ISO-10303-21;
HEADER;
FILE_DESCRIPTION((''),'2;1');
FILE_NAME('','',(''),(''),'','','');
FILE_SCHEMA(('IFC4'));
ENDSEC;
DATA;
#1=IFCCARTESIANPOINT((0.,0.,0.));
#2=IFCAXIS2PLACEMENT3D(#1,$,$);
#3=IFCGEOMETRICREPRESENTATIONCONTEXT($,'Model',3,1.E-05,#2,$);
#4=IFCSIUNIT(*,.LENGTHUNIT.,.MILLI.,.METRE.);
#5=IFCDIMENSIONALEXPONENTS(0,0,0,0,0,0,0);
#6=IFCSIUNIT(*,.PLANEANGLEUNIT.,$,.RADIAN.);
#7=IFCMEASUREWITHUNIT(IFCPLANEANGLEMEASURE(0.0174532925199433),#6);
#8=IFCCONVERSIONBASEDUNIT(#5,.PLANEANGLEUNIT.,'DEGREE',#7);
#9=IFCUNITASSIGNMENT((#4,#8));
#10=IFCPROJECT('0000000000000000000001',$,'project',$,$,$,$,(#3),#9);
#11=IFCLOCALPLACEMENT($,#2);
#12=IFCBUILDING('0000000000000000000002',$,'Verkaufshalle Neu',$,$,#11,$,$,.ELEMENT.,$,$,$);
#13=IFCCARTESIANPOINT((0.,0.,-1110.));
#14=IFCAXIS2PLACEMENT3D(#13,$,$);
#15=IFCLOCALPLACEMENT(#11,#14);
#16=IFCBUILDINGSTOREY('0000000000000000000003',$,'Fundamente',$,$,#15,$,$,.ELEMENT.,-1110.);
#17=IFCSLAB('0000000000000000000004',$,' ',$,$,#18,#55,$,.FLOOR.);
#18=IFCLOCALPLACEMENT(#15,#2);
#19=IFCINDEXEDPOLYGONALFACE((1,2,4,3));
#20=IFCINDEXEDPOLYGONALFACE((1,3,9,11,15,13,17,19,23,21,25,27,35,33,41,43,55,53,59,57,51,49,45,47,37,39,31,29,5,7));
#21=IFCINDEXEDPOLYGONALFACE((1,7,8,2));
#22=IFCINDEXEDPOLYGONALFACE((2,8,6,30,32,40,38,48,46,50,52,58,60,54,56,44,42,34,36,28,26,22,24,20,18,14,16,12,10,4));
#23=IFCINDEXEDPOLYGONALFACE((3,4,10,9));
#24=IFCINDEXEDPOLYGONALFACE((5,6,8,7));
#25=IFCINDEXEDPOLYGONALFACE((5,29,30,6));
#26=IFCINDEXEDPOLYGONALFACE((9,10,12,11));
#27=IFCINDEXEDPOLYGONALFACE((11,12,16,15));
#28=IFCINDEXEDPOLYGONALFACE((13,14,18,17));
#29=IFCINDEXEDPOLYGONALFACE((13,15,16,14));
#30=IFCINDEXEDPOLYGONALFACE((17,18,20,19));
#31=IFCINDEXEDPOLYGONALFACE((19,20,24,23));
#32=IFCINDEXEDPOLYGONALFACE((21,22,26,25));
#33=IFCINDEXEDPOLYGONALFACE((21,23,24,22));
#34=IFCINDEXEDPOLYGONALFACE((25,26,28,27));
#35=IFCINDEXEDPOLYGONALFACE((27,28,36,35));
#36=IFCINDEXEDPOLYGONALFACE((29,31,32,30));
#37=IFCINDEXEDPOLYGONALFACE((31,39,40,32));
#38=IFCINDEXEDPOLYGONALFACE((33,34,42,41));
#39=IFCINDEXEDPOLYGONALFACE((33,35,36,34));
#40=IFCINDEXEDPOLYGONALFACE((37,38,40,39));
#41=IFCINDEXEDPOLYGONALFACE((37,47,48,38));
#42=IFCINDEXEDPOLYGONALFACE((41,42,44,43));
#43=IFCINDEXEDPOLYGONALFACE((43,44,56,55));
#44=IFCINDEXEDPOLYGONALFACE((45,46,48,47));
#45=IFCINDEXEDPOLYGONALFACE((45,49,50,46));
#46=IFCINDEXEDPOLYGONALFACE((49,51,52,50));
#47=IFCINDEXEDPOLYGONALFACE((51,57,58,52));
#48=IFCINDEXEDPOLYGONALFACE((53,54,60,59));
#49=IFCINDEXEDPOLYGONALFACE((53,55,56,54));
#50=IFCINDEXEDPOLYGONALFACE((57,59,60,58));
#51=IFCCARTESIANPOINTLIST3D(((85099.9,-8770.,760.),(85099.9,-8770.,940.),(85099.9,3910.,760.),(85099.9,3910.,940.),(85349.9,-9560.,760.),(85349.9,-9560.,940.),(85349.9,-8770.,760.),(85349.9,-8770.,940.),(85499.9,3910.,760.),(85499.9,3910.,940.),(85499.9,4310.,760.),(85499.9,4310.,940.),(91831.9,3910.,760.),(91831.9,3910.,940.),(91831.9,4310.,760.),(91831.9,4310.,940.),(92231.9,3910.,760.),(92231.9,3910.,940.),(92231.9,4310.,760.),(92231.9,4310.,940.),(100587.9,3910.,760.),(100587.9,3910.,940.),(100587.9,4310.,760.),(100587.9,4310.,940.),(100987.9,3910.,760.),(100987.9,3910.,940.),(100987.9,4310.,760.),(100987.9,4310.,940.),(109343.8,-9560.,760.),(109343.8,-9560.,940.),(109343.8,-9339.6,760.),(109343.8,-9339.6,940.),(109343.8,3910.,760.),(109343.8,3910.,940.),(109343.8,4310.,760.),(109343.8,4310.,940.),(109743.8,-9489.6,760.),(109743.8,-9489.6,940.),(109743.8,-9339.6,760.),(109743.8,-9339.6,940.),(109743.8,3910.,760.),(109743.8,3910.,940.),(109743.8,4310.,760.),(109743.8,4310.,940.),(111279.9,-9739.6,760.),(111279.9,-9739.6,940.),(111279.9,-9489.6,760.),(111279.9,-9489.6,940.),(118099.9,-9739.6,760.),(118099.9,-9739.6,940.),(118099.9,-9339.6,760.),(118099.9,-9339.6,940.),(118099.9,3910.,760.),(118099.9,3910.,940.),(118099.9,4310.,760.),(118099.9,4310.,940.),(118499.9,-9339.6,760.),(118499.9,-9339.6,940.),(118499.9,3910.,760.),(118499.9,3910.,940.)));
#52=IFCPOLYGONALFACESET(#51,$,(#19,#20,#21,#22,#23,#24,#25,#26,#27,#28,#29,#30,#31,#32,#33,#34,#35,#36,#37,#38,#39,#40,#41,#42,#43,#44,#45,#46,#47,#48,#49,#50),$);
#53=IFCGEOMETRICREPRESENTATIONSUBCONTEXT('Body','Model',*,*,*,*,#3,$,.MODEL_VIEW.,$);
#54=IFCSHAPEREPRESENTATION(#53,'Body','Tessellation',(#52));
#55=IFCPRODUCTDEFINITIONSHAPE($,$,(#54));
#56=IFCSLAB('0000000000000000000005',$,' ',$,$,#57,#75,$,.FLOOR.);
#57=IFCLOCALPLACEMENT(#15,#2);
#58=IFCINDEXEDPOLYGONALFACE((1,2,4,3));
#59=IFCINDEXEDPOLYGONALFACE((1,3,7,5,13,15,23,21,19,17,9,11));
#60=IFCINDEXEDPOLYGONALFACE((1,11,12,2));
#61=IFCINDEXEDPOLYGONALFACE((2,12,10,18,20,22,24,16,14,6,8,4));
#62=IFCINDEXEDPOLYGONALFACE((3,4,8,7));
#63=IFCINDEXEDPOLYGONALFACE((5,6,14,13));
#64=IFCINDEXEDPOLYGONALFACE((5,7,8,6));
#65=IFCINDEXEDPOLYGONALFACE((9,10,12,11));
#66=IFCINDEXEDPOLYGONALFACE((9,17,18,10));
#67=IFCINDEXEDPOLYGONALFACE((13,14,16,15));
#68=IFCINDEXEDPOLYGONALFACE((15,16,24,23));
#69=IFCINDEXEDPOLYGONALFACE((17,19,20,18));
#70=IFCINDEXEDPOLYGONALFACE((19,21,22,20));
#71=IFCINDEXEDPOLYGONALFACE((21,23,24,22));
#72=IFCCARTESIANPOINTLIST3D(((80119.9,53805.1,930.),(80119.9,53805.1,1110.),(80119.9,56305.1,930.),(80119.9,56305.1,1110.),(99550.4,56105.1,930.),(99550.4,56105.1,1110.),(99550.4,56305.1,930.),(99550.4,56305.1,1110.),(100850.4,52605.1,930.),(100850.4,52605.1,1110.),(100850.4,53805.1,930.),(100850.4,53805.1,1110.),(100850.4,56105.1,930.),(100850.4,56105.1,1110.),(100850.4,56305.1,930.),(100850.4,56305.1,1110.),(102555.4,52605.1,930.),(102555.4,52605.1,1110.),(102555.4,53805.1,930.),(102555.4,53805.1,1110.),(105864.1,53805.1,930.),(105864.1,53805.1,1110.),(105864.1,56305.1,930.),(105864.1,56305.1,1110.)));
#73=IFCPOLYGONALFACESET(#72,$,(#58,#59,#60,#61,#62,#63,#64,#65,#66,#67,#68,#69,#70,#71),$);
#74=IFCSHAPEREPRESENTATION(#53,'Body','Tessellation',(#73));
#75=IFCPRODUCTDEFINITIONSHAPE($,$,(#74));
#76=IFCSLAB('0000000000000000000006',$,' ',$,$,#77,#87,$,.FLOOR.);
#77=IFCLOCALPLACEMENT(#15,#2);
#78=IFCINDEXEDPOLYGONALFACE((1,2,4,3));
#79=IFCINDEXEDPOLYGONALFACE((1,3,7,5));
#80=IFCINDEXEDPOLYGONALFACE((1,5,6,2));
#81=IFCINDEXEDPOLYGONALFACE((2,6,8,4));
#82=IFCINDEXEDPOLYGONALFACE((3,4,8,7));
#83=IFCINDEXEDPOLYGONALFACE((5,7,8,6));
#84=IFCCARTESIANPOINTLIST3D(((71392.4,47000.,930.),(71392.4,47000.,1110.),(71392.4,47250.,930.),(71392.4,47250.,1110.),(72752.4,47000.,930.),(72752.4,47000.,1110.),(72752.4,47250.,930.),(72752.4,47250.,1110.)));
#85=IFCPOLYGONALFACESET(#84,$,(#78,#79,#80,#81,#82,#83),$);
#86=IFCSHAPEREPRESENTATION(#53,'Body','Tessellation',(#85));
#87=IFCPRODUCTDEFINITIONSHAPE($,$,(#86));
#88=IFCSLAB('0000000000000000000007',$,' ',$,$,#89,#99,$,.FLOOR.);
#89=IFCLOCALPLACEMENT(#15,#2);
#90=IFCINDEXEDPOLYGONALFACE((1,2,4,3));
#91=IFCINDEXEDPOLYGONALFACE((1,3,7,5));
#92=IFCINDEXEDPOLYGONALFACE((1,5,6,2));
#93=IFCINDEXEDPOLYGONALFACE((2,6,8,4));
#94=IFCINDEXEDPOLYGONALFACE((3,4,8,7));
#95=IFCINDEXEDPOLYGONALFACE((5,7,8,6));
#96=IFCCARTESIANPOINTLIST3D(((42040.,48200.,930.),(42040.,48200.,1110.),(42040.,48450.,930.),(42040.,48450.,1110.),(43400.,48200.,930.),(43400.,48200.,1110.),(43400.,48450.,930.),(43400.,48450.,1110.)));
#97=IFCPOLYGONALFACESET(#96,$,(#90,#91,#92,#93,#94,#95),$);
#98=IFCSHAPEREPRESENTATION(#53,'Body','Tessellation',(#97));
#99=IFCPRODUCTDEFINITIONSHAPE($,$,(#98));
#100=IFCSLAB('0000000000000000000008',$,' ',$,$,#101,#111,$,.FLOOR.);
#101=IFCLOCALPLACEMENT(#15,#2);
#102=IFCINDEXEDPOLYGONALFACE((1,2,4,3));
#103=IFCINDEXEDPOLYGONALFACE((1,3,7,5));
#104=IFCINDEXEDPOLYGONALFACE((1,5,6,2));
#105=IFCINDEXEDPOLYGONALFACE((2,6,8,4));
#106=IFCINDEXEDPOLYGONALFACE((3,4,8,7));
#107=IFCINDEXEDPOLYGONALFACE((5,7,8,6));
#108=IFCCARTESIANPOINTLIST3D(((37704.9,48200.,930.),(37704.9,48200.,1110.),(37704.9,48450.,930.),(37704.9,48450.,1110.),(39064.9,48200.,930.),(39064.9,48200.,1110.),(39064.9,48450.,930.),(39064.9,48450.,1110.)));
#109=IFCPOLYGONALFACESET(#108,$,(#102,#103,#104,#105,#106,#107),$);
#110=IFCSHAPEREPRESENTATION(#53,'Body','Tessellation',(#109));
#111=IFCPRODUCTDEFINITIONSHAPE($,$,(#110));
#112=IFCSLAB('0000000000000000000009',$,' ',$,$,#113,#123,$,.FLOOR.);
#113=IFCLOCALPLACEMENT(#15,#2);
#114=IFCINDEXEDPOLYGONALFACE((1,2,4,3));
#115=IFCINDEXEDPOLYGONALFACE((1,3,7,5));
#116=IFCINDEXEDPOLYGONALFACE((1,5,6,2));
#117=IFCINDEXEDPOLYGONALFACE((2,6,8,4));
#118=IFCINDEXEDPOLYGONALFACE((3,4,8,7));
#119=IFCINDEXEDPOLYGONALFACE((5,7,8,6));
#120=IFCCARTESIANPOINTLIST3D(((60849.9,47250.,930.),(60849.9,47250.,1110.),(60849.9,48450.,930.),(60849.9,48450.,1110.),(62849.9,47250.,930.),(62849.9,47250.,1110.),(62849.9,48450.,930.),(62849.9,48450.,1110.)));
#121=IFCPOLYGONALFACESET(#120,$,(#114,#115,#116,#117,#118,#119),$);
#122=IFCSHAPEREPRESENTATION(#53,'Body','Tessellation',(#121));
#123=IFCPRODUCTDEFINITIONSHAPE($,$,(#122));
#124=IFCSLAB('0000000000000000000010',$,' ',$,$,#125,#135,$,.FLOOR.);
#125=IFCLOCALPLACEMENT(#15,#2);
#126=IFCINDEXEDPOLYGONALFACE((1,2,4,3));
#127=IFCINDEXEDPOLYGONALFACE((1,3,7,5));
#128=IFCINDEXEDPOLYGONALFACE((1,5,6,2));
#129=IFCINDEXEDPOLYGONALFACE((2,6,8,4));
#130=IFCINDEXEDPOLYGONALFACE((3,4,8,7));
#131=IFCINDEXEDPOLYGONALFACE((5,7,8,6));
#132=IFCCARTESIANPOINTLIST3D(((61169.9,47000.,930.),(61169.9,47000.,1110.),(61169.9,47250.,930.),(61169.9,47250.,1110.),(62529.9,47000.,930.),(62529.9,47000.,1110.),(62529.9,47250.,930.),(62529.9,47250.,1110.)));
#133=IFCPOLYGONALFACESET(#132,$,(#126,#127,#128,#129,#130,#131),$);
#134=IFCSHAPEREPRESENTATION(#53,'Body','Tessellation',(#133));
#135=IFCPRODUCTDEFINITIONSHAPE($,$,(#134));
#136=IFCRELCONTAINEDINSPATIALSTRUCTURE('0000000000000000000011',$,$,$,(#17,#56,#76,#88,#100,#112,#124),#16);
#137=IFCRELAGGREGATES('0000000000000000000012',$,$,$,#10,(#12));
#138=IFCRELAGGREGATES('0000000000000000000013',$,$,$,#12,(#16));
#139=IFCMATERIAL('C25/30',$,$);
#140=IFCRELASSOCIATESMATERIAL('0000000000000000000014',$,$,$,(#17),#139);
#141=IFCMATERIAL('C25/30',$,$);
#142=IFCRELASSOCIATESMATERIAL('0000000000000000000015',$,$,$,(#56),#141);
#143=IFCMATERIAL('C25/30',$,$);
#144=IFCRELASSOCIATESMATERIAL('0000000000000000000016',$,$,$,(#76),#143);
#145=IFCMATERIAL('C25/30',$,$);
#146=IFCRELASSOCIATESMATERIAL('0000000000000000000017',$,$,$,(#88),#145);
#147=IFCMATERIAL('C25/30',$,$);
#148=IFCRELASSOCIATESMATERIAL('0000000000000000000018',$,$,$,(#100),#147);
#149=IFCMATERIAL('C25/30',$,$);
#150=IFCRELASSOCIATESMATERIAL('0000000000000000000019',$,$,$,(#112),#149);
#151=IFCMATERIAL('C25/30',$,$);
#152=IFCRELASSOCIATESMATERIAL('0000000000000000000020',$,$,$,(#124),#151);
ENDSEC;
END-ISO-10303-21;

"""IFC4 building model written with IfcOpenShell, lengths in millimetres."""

from ifc_helpers import new_model, entity, si_unit, converted_unit, frame, frame_2d, origin, origin_with_axes, place, context, subcontext, project, spatial, polyline, rectangle, outline, extrude, material, element, save


model = new_model("IFC4")

# Units and contexts
model_context = context("Model", 3, precision=1e-05, world=origin())
body_context = subcontext(model_context, "Body", "Model", "MODEL_VIEW")
ifc_project = project(units=[si_unit("LENGTHUNIT", "METRE", prefix="MILLI"), converted_unit("PLANEANGLEUNIT", "DEGREE", entity("IfcPlaneAngleMeasure", 0.0174532925199433), si_unit("PLANEANGLEUNIT", "RADIAN"), dimensions=[0, 0, 0, 0, 0, 0, 0])], contexts=[model_context])

# Building, storey
building_placement = place(None, origin())
building = spatial("IfcBuilding", under=ifc_project, at=building_placement, Name="Verkaufshalle Neu", CompositionType="ELEMENT")
storey_placement = place(building_placement, frame((0.0, 0.0, -1110.0)))
storey = spatial("IfcBuildingStorey", under=building, at=storey_placement, Name="Fundamente", CompositionType="ELEMENT", Elevation=-1110.0)

# Slab
ifc_material_1 = material(Name="C25/30")
slab_1_placement = place(storey_placement, frame((85099.9, -9739.6, 760.0)))
element("IfcSlab", 1, at=slab_1_placement, inside=storey, material=ifc_material_1, Name=" ", PredefinedType="FLOOR", context=body_context, shape_type="SweptSolid", body=[
    extrude(outline(polyline([(0.0, 969.6), (250.0, 969.6), (250.0, 179.6), (24243.9, 179.6), (24243.9, 400.0), (24643.9, 400.0), (24643.9, 250.0), (26180.0, 250.0), (26180.0, 0.0), (33000.0, 0.0), (33000.0, 400.0), (33400.0, 400.0), (33400.0, 13649.6), (33000.0, 13649.6), (33000.0, 14049.6), (24643.9, 14049.6), (24643.9, 13649.6), (24243.9, 13649.6), (24243.9, 14049.6), (15888.0, 14049.6), (15888.0, 13649.6), (15488.0, 13649.6), (15488.0, 14049.6), (7132.0, 14049.6), (7132.0, 13649.6), (6732.0, 13649.6), (6732.0, 14049.6), (400.0, 14049.6), (400.0, 13649.6), (0.0, 13649.6), (0.0, 969.6)])), origin_with_axes(), (0.0, 0.0, 1.0), 180.0),
])

# Slab, opening
ifc_material_2 = material(Name="C25/30")
slab_2_placement = place(storey_placement, frame((80119.9, 52605.1, 930.0)))
slab_2 = element("IfcSlab", 2, at=slab_2_placement, inside=storey, material=ifc_material_2, Name=" ", PredefinedType="FLOOR", context=body_context, shape_type="SweptSolid", body=[
    extrude(outline(polyline([(0.0, 1200.0), (20730.5, 1200.0), (20730.5, 0.0), (22435.5, 0.0), (22435.5, 1200.0), (25744.1, 1200.0), (25744.1, 3700.0), (0.0, 3700.0), (0.0, 1200.0)])), origin_with_axes(), (0.0, 0.0, 1.0), 180.0),
])
opening_1_placement = place(slab_2_placement, frame((19430.5, 3500.0, 0.0)))
element("IfcOpeningStandardCase", 3, at=opening_1_placement, cuts=slab_2, PredefinedType="OPENING", context=body_context, shape_type="SweptSolid", body=[
    extrude(rectangle(XDim=200.0, YDim=1300.0, at=frame_2d((0.0, 0.0), x_axis=(0.0, -1.0))), frame((650.0, 100.0, 0.0), z_axis=(0.0, 0.0, 1.0), x_axis=(1.0, 0.0, 0.0)), (0.0, 0.0, 1.0), 180.0),
])

# Slabs
ifc_material_3 = material(Name="C25/30")
slab_3_placement = place(storey_placement, frame((71392.4, 47000.0, 930.0)))
element("IfcSlab", 4, at=slab_3_placement, inside=storey, material=ifc_material_3, Name=" ", PredefinedType="FLOOR", context=body_context, shape_type="SweptSolid", body=[
    extrude(rectangle(XDim=250.0, YDim=1360.0, at=frame_2d((680.0, -125.0), x_axis=(0.0, -1.0))), frame((0.0, 250.0, 0.0), z_axis=(0.0, 0.0, 1.0), x_axis=(1.0, 0.0, 0.0)), (0.0, 0.0, 1.0), 180.0),
])
ifc_material_4 = material(Name="C25/30")
slab_4_placement = place(storey_placement, frame((42040.0, 48200.0, 930.0)))
element("IfcSlab", 5, at=slab_4_placement, inside=storey, material=ifc_material_4, Name=" ", PredefinedType="FLOOR", context=body_context, shape_type="SweptSolid", body=[
    extrude(rectangle(XDim=250.0, YDim=1360.0, at=frame_2d((680.0, -125.0), x_axis=(0.0, -1.0))), frame((0.0, 250.0, 0.0), z_axis=(0.0, 0.0, 1.0), x_axis=(1.0, 0.0, 0.0)), (0.0, 0.0, 1.0), 180.0),
])
ifc_material_5 = material(Name="C25/30")
slab_5_placement = place(storey_placement, frame((37704.9, 48200.0, 930.0)))
element("IfcSlab", 6, at=slab_5_placement, inside=storey, material=ifc_material_5, Name=" ", PredefinedType="FLOOR", context=body_context, shape_type="SweptSolid", body=[
    extrude(rectangle(XDim=250.0, YDim=1360.0, at=frame_2d((680.0, -125.0), x_axis=(0.0, -1.0))), frame((0.0, 250.0, 0.0), z_axis=(0.0, 0.0, 1.0), x_axis=(1.0, 0.0, 0.0)), (0.0, 0.0, 1.0), 180.0),
])
ifc_material_6 = material(Name="C25/30")
slab_6_placement = place(storey_placement, frame((60849.9, 47250.0, 930.0)))
element("IfcSlab", 7, at=slab_6_placement, inside=storey, material=ifc_material_6, Name=" ", PredefinedType="FLOOR", context=body_context, shape_type="SweptSolid", body=[
    extrude(rectangle(XDim=1200.0, YDim=2000.0, at=frame_2d((1000.0, -600.0), x_axis=(0.0, -1.0))), frame((0.0, 1200.0, 0.0), z_axis=(0.0, 0.0, 1.0), x_axis=(1.0, 0.0, 0.0)), (0.0, 0.0, 1.0), 180.0),
])
ifc_material_7 = material(Name="C25/30")
slab_7_placement = place(storey_placement, frame((61169.9, 47000.0, 930.0)))
element("IfcSlab", 8, at=slab_7_placement, inside=storey, material=ifc_material_7, Name=" ", PredefinedType="FLOOR", context=body_context, shape_type="SweptSolid", body=[
    extrude(rectangle(XDim=250.0, YDim=1360.0, at=frame_2d((680.0, -125.0), x_axis=(0.0, -1.0))), frame((0.0, 250.0, 0.0), z_axis=(0.0, 0.0, 1.0), x_axis=(1.0, 0.0, 0.0)), (0.0, 0.0, 1.0), 180.0),
])

save(model, "model.ifc")
